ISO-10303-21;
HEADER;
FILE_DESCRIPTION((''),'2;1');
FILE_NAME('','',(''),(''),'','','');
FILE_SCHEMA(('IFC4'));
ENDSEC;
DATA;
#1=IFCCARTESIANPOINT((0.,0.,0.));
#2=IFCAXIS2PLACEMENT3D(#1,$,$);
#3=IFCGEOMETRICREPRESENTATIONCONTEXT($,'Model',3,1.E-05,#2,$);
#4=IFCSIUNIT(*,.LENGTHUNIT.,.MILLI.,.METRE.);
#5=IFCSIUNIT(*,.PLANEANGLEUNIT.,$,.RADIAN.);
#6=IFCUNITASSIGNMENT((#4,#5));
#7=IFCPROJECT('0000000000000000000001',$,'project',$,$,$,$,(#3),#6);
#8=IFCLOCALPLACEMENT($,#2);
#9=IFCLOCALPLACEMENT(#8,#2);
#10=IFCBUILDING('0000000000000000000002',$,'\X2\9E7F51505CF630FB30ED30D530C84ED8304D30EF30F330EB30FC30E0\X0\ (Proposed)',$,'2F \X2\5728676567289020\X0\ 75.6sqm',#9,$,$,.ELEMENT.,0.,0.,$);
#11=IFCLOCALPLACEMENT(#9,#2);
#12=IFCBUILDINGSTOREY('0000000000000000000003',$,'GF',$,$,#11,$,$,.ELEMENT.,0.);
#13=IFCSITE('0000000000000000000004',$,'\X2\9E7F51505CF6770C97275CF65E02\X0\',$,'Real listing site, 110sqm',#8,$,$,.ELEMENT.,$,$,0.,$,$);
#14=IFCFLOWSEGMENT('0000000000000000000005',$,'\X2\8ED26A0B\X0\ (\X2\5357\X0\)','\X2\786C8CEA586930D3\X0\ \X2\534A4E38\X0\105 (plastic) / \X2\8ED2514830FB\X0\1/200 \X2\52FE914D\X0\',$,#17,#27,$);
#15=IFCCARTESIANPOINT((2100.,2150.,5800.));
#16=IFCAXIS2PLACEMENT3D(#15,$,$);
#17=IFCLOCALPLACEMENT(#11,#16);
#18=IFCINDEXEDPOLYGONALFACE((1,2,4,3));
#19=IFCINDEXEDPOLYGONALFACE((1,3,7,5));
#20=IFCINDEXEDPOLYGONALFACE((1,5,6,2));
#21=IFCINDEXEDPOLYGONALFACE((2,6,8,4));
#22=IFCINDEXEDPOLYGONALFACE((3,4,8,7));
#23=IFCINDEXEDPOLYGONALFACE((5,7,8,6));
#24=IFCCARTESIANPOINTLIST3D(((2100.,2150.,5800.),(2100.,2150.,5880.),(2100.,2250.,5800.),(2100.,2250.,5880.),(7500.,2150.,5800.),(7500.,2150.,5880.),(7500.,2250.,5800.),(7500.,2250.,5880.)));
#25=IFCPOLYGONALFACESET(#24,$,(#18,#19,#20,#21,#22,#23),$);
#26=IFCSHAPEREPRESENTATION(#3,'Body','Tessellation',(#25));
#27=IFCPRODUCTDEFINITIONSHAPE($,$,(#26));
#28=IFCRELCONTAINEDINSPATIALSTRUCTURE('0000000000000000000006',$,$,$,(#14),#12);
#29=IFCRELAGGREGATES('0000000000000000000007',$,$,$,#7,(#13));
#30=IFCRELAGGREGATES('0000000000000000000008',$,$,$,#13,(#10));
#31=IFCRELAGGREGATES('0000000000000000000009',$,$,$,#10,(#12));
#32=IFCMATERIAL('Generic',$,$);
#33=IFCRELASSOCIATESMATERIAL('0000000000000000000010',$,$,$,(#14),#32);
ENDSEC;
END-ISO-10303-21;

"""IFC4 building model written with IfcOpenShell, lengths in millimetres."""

from ifc_helpers import new_model, si_unit, frame, frame_2d, origin, place, context, project, spatial, rectangle, extrude, material, element, save


model = new_model("IFC4")

# Units and contexts
model_context = context("Model", 3, precision=1e-05, world=origin())
ifc_project = project(units=[si_unit("LENGTHUNIT", "METRE", prefix="MILLI"), si_unit("PLANEANGLEUNIT", "RADIAN")], contexts=[model_context])

# Site, building, storey
site_placement = place(None, origin())
site = spatial("IfcSite", under=ifc_project, at=site_placement, Name="鹿児島県霧島市", ObjectType="Real listing site, 110sqm", CompositionType="ELEMENT", RefElevation=0.0)
building_placement = place(site_placement, origin())
building = spatial("IfcBuilding", under=site, at=building_placement, Name="鹿児島・ロフト付きワンルーム (Proposed)", ObjectType="2F 在来木造 75.6sqm", CompositionType="ELEMENT", ElevationOfRefHeight=0.0, ElevationOfTerrain=0.0)
storey_placement = place(building_placement, origin())
storey = spatial("IfcBuildingStorey", under=building, at=storey_placement, Name="GF", CompositionType="ELEMENT", Elevation=0.0)

# Flow segment
ifc_material_1 = material(Name="Generic")
flow_segment_placement = place(storey_placement, frame((2100.0, 2150.0, 5800.0)))
element("IfcFlowSegment", 1, at=flow_segment_placement, inside=storey, material=ifc_material_1, Name="軒樋 (南)", Description="硬質塩ビ 半丸105 (plastic) / 軒先・1/200 勾配", context=model_context, shape_type="SweptSolid", body=[
    extrude(rectangle(XDim=5400.0, YDim=100.0, at=frame_2d((2700.0, 50.0))), frame((2100.0, 2150.0, 5800.0)), (0.0, 0.0, 1.0), 80.0),
])

save(model, "model.ifc")
